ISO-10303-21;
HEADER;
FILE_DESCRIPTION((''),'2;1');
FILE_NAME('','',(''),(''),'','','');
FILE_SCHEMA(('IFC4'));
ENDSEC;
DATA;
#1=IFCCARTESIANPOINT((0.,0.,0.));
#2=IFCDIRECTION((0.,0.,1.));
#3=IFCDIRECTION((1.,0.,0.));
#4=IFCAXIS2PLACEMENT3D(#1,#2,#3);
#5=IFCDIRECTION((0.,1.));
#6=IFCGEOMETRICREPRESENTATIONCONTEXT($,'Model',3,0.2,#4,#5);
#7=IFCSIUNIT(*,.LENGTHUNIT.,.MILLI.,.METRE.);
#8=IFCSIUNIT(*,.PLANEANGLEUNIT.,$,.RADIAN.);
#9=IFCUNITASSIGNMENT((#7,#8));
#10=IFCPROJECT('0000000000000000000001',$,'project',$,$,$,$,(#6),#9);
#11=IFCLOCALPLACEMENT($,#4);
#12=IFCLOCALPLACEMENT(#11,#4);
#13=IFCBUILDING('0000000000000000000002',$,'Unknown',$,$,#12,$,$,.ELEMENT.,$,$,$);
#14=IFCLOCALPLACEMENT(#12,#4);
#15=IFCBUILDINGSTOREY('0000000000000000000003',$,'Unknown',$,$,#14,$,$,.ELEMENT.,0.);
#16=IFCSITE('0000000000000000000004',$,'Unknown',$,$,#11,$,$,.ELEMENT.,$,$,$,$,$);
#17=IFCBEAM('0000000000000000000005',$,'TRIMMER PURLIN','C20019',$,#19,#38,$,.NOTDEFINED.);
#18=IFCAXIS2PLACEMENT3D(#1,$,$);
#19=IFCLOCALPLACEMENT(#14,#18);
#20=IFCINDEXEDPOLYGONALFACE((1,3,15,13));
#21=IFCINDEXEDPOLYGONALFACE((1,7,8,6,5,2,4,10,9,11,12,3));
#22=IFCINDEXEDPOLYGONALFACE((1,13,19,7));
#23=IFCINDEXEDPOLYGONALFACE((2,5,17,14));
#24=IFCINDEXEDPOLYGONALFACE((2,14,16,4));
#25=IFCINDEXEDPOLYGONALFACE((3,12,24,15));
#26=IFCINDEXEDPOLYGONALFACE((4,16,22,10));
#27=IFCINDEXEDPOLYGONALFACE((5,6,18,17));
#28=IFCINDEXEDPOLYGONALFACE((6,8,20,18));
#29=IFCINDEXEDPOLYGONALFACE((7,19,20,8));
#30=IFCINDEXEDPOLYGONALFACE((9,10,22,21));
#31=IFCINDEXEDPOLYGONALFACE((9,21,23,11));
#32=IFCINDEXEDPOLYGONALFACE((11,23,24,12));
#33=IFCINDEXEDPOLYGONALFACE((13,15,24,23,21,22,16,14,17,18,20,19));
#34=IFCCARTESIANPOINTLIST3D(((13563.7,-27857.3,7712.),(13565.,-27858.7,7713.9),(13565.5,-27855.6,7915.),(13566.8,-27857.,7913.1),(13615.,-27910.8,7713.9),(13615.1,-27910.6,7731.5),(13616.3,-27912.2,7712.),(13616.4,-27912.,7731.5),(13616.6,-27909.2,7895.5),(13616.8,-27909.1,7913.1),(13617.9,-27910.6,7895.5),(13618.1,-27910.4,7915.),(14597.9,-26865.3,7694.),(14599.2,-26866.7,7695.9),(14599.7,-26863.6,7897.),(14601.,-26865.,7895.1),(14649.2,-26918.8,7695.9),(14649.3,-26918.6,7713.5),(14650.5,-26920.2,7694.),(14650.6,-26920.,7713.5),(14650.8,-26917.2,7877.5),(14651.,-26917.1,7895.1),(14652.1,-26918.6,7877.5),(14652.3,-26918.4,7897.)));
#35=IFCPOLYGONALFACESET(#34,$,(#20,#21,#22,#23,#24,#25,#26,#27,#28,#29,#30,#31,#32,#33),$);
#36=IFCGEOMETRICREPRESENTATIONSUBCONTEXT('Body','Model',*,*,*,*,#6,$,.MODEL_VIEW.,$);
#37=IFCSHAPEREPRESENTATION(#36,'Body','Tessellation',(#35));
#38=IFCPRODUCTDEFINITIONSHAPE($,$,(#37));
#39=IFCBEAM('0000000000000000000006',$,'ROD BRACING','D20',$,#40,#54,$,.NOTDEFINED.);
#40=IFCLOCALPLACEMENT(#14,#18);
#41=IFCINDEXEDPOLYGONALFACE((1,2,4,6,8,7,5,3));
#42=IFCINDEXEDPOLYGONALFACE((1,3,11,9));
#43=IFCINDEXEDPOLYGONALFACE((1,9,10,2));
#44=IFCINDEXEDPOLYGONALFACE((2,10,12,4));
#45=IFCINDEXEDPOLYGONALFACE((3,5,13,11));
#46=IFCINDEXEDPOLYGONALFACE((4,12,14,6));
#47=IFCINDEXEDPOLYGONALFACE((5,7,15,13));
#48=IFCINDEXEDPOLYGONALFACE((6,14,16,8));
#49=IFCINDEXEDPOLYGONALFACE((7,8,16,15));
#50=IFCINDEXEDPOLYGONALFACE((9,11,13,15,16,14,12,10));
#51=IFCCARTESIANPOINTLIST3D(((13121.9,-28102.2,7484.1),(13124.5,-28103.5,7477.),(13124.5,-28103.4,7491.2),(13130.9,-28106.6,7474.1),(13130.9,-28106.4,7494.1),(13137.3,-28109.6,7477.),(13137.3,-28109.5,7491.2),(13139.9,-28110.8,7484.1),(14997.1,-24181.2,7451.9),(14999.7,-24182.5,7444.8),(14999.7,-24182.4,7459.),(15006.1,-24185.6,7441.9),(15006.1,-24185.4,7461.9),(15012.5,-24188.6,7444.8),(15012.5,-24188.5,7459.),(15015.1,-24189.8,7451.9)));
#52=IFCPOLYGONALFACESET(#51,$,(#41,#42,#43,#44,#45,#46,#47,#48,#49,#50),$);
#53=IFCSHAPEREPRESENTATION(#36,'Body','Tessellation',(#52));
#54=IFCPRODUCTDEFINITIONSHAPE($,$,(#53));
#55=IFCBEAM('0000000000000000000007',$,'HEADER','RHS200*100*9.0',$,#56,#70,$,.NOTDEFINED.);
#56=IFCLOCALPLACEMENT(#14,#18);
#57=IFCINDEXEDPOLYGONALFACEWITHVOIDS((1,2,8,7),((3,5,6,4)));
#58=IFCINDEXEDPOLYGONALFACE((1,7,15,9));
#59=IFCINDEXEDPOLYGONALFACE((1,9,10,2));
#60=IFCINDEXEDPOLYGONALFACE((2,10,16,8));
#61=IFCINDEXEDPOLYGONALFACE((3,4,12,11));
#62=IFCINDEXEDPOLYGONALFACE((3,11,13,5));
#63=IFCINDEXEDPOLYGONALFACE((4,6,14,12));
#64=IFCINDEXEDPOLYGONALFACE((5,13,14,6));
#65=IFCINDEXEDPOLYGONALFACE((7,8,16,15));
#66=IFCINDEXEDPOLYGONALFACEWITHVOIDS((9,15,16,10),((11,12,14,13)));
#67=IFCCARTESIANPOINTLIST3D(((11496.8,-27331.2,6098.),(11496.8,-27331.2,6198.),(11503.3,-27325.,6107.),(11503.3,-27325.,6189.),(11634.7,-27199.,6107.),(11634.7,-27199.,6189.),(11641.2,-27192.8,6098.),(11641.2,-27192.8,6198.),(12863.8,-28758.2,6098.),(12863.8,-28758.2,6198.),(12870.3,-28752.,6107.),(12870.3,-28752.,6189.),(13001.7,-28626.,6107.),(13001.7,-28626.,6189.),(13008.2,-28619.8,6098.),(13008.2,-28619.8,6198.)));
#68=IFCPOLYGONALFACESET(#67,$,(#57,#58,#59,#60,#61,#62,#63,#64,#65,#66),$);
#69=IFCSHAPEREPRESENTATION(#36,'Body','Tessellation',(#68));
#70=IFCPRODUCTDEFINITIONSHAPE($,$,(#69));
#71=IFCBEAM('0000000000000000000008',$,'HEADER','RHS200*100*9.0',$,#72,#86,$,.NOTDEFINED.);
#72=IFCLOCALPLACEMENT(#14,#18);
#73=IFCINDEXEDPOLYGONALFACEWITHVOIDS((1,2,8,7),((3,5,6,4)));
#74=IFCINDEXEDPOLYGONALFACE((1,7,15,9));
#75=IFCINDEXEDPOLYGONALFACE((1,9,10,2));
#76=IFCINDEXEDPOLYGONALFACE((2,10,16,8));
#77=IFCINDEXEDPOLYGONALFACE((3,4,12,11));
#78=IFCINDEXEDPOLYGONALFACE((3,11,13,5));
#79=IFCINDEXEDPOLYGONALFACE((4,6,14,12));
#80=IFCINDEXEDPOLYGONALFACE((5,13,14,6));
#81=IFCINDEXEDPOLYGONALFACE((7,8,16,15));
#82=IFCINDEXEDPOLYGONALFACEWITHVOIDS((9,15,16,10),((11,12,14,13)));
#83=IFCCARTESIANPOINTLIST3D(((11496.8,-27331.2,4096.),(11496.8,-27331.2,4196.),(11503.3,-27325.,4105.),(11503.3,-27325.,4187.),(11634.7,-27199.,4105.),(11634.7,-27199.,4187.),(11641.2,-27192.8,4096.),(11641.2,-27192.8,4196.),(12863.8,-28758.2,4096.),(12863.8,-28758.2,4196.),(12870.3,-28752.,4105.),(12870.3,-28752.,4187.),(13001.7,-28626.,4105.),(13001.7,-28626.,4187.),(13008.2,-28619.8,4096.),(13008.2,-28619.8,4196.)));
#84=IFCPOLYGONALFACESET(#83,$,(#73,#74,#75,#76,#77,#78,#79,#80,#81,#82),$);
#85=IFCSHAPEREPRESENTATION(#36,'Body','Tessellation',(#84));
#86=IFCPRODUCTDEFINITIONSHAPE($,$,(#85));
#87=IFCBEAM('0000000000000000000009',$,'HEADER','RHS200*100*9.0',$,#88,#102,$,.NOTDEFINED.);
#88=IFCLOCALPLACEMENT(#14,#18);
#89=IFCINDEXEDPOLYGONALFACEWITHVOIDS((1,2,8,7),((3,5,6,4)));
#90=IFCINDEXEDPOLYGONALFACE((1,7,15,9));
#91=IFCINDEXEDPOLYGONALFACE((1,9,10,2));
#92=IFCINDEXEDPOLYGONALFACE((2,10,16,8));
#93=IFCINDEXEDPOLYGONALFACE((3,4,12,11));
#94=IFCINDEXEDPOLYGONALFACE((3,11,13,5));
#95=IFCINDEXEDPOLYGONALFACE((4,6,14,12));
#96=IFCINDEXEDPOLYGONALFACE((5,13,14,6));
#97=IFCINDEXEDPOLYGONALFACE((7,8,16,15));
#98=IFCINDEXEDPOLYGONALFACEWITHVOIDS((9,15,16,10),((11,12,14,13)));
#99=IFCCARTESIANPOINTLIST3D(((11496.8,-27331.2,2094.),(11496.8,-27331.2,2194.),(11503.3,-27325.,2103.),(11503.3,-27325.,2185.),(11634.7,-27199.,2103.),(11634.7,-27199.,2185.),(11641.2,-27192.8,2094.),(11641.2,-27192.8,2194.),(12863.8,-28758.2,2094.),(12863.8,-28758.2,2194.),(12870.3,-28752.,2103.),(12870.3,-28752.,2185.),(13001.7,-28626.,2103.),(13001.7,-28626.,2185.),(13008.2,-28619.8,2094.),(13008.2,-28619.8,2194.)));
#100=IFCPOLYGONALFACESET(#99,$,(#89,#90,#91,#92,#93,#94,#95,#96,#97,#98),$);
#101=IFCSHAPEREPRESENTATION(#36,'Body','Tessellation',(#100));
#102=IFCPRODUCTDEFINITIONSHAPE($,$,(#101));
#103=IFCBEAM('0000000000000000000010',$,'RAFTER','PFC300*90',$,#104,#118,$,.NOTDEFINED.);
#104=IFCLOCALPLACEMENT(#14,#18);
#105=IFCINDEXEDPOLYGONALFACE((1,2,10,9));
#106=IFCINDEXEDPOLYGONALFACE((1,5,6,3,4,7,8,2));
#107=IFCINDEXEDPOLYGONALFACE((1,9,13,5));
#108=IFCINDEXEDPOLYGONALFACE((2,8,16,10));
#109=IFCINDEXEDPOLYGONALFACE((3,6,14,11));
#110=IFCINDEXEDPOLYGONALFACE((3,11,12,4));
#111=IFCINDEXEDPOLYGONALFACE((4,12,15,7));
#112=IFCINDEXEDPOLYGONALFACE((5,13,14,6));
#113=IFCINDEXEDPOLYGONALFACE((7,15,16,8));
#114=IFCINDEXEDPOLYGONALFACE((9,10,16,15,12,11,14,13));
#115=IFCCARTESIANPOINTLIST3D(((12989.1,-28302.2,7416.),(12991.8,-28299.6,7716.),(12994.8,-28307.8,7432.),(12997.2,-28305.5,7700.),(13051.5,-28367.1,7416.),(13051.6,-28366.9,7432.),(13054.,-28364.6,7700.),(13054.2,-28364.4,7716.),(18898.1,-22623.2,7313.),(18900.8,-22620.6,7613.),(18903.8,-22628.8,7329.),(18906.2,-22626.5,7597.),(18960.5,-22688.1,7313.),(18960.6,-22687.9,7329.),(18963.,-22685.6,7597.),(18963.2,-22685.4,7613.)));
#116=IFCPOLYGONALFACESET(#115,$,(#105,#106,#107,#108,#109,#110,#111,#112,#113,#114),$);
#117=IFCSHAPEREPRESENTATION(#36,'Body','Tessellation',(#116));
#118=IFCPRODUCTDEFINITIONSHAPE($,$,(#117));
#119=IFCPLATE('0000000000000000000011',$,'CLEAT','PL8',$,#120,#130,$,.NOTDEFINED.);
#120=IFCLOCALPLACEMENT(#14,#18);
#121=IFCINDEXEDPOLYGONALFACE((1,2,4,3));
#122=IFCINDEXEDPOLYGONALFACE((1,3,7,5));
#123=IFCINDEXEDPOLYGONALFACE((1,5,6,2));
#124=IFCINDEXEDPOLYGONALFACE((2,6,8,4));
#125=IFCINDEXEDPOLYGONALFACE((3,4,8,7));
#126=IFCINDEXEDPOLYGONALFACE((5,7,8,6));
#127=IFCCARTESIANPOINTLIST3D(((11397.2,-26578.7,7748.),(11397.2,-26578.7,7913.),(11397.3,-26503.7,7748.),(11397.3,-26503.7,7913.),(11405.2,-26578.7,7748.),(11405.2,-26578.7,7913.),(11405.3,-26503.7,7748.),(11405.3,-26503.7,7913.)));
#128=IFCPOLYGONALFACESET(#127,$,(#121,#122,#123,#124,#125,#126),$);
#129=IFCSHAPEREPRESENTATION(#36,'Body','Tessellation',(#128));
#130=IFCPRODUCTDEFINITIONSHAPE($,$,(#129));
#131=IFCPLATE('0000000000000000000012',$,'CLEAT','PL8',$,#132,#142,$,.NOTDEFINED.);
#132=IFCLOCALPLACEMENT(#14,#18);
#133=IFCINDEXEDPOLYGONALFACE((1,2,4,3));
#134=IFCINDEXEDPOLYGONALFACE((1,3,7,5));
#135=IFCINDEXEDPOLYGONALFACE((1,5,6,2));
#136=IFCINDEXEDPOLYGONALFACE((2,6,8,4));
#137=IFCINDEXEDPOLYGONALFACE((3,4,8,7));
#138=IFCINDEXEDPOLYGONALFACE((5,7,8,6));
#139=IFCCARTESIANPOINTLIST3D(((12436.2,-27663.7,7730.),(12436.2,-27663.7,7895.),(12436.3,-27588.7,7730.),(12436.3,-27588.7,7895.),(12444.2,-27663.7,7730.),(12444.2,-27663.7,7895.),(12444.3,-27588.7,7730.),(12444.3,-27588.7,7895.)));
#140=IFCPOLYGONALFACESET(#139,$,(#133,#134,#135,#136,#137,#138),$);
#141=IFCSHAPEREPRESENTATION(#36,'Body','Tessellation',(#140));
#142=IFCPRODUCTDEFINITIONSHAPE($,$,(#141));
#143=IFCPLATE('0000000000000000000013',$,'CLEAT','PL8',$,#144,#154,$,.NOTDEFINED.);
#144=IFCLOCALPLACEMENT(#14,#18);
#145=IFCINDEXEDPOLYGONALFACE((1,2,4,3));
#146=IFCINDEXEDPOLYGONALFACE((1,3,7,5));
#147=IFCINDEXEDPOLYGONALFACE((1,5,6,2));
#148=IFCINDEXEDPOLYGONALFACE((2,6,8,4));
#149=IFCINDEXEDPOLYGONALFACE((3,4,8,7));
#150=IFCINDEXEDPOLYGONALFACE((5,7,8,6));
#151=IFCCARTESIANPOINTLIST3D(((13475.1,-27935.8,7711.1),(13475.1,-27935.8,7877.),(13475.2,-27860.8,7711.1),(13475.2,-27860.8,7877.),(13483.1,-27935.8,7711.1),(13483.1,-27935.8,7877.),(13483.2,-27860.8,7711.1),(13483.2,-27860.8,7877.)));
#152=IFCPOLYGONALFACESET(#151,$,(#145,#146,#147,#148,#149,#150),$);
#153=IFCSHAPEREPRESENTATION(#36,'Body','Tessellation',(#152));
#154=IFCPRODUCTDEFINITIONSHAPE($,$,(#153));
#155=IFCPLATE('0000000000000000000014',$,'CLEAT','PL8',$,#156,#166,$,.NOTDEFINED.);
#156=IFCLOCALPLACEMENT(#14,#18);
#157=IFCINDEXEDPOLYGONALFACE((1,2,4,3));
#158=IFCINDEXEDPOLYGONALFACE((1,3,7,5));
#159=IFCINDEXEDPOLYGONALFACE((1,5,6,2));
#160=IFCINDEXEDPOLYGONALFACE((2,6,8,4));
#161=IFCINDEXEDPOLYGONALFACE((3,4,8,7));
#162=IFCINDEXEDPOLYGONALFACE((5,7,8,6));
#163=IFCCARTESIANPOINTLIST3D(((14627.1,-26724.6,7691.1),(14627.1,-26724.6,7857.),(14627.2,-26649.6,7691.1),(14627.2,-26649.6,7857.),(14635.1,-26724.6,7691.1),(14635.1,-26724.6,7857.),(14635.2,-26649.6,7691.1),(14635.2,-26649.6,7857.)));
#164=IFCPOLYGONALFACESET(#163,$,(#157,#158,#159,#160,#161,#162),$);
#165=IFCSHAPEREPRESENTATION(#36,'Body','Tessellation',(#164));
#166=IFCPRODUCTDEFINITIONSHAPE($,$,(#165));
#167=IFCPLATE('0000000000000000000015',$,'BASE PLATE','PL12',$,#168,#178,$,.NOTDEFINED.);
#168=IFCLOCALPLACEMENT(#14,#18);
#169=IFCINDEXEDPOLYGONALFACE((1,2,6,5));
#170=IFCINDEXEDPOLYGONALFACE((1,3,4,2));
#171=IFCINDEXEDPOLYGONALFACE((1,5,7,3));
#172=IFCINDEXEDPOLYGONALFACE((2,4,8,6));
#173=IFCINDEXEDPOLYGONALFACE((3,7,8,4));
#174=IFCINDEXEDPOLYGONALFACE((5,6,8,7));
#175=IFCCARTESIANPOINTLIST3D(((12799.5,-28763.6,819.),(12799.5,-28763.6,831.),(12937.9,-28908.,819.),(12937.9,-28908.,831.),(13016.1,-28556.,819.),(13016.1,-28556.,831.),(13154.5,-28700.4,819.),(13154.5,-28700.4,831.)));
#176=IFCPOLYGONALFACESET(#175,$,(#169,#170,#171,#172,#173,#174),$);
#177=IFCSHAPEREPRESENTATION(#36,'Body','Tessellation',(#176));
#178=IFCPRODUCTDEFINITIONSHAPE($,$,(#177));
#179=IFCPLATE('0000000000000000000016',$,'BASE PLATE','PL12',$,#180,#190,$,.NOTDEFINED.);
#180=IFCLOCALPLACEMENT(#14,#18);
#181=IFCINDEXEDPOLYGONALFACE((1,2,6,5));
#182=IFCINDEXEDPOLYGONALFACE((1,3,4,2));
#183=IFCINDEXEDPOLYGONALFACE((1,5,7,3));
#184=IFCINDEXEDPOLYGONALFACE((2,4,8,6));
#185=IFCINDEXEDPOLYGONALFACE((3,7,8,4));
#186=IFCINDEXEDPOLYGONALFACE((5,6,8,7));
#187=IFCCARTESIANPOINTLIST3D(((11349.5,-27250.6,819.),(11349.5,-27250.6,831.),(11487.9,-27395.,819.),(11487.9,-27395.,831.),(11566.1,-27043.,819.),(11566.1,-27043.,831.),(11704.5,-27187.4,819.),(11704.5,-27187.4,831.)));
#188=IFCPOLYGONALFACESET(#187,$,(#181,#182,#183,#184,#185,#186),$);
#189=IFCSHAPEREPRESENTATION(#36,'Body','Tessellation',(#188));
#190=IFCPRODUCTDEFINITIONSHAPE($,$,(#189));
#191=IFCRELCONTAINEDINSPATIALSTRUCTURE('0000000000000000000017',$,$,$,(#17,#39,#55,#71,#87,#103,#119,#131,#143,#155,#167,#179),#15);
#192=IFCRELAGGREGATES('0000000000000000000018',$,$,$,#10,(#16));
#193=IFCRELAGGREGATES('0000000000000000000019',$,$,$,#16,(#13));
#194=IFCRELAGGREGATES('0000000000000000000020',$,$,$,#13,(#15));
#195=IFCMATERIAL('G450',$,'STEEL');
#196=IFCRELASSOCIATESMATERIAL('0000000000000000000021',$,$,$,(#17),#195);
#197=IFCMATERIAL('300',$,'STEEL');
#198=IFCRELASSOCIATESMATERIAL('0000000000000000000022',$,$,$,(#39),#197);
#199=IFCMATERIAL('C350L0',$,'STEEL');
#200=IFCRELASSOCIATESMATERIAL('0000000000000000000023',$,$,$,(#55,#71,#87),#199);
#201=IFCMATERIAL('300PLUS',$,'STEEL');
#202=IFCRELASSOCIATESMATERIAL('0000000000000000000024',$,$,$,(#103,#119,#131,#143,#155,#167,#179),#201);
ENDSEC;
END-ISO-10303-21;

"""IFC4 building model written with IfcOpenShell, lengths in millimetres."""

from ifc_helpers import new_model, si_unit, direction, frame, origin_with_axes, place, context, subcontext, project, spatial, line, indexed_curve, outline, extrude, material, element, save


model = new_model("IFC4")

# Units and contexts
model_context = context("Model", 3, precision=0.2, world=origin_with_axes(), true_north=direction((0.0, 1.0)))
body_context = subcontext(model_context, "Body", "Model", "MODEL_VIEW")
ifc_project = project(units=[si_unit("LENGTHUNIT", "METRE", prefix="MILLI"), si_unit("PLANEANGLEUNIT", "RADIAN")], contexts=[model_context])

# Site, building, storey
site_placement = place(None, origin_with_axes())
site = spatial("IfcSite", under=ifc_project, at=site_placement, Name="Unknown", CompositionType="ELEMENT")
building_placement = place(site_placement, origin_with_axes())
building = spatial("IfcBuilding", under=site, at=building_placement, Name="Unknown", CompositionType="ELEMENT")
storey_placement = place(building_placement, origin_with_axes())
storey = spatial("IfcBuildingStorey", under=building, at=storey_placement, Name="Unknown", CompositionType="ELEMENT", Elevation=0.0)

# Shared definitions
ifc_material_1 = material(Name="C350L0", Category="STEEL")

# Beams
ifc_material_2 = material(Name="G450", Category="STEEL")
beam_1_placement = place(storey_placement, frame((13590.9, -27883.9, 7813.5), z_axis=(0.69223, -0.721677, 0.0), x_axis=(0.72162, 0.692175, -0.01256)))
element("IfcBeam", 1, at=beam_1_placement, inside=storey, material=ifc_material_2, Name="TRIMMER PURLIN", Description="C20019", PredefinedType="NOTDEFINED", context=body_context, shape_type="SolidModel", body=[
    extrude(outline(indexed_curve([(38.0, -101.5), (38.0, -82.0), (36.1, -82.0), (36.1, -99.6), (-36.1, -99.6), (-36.1, 99.6), (36.1, 99.6), (36.1, 82.0), (38.0, 82.0), (38.0, 101.5), (-38.0, 101.5), (-38.0, -101.5)], segments=[line(1, 2, 3, 4, 5, 6, 7, 8, 9, 10, 11, 12, 1)])), frame((0.0, 0.0, 0.0), z_axis=(-1.0, 0.0, 0.0), x_axis=(0.0, 0.0, 1.0)), (0.0, 0.0, -1.0), 1433.2),
])
ifc_material_3 = material(Name="300", Category="STEEL")
beam_2_placement = place(storey_placement, frame((13130.9, -28106.5, 7484.1), z_axis=(0.003196, 0.006683, 0.999973), x_axis=(0.431432, 0.902115, -0.007408)))
element("IfcBeam", 2, at=beam_2_placement, inside=storey, material=ifc_material_3, Name="ROD BRACING", Description="D20", PredefinedType="NOTDEFINED", context=body_context, shape_type="SolidModel", body=[
    extrude(outline(indexed_curve([(10.0, 0.0), (7.1, 7.1), (0.0, 10.0), (-7.1, 7.1), (-10.0, 0.0), (-7.1, -7.1), (0.0, -10.0), (7.1, -7.1)], segments=[line(1, 2, 3, 4, 5, 6, 7, 8, 1)])), frame((0.0, 0.0, 0.0), z_axis=(-1.0, 0.0, 0.0), x_axis=(0.0, 0.0, 1.0)), (0.0, 0.0, -1.0), 4346.5),
])
for number, where, z_axis, x_axis, name in (
    (3, (11569.0, -27262.0, 6148.0), (0.0, 0.0, 1.0), (0.691762, -0.722125, 0.0), "HEADER"),
    (4, (11569.0, -27262.0, 4146.0), (0.0, 0.0, 1.0), (0.691762, -0.722125, 0.0), "HEADER"),
    (5, (11569.0, -27262.0, 2144.0), (0.0, 0.0, 1.0), (0.691762, -0.722125, 0.0), "HEADER"),
):
    element("IfcBeam", number, at=place(storey_placement, frame(where, z_axis=z_axis, x_axis=x_axis)), inside=storey, material=ifc_material_1, Name=name, Description="RHS200*100*9.0", PredefinedType="NOTDEFINED", context=body_context, shape_type="SolidModel", body=[
        extrude(outline(indexed_curve([(-50.0, -100.0), (50.0, -100.0), (50.0, 100.0), (-50.0, 100.0)], segments=[line(1, 2, 3, 4, 1)]), holes=[indexed_curve([(-41.0, -91.0), (-41.0, 91.0), (41.0, 91.0), (41.0, -91.0)], segments=[line(1, 2, 3, 4, 1)])]), frame((0.0, 0.0, 0.0), z_axis=(-1.0, 0.0, 0.0), x_axis=(0.0, 0.0, 1.0)), (0.0, 0.0, -1.0), 1976.1),
    ])
ifc_material_4 = material(Name="300PLUS", Category="STEEL")
beam_3_placement = place(storey_placement, frame((13021.6, -28333.3, 7566.0), z_axis=(0.692936, -0.721, 0.0), x_axis=(0.720943, 0.692881, -0.012567)))
element("IfcBeam", 6, at=beam_3_placement, inside=storey, material=ifc_material_4, Name="RAFTER", Description="PFC300*90", PredefinedType="NOTDEFINED", context=body_context, shape_type="SolidModel", body=[
    extrude(outline(indexed_curve([(-45.0, -150.0), (45.0, -150.0), (45.0, -134.0), (-37.0, -134.0), (-37.0, 134.0), (45.0, 134.0), (45.0, 150.0), (-45.0, 150.0)], segments=[line(1, 2, 3, 4, 5, 6, 7, 8, 1)])), frame((0.0, 0.0, 0.0), z_axis=(-1.0, 0.0, 0.0), x_axis=(0.0, 0.0, 1.0)), (0.0, 0.0, -1.0), 8196.2),
])

# Plates
for number, where, z_axis, x_axis, name in (
    (7, (11401.3, -26503.7, 7913.0), (0.999999, -0.001333, 0.0), (-0.001333, -0.999999, 0.0), "CLEAT"),
    (8, (12440.3, -27588.7, 7895.0), (0.999999, -0.001333, 0.0), (-0.001333, -0.999999, 0.0), "CLEAT"),
):
    element("IfcPlate", number, at=place(storey_placement, frame(where, z_axis=z_axis, x_axis=x_axis)), inside=storey, material=ifc_material_4, Name=name, Description="PL8", PredefinedType="NOTDEFINED", context=body_context, shape_type="SolidModel", body=[
        extrude(outline(indexed_curve([(0.0, 0.0), (75.0, 0.0), (75.0, 165.0), (0.0, 165.0)], segments=[line(1, 2, 3, 4, 1)])), frame((0.0, 0.0, 4.0), z_axis=(0.0, 0.0, 1.0), x_axis=(1.0, 0.0, 0.0)), (0.0, 0.0, -1.0), 8.0),
    ])
for number, where, z_axis, x_axis, name in (
    (9, (13479.2, -27860.8, 7877.0), (0.999999, -0.001333, 0.0), (-0.001333, -0.999999, 0.0), "CLEAT"),
    (10, (14631.2, -26649.6, 7857.0), (0.999999, -0.001333, 0.0), (-0.001333, -0.999999, 0.0), "CLEAT"),
):
    element("IfcPlate", number, at=place(storey_placement, frame(where, z_axis=z_axis, x_axis=x_axis)), inside=storey, material=ifc_material_4, Name=name, Description="PL8", PredefinedType="NOTDEFINED", context=body_context, shape_type="SolidModel", body=[
        extrude(outline(indexed_curve([(0.0, 0.0), (75.0, 0.0), (75.0, 165.9), (0.0, 165.9)], segments=[line(1, 2, 3, 4, 1)])), frame((0.0, 0.0, 4.0), z_axis=(0.0, 0.0, 1.0), x_axis=(1.0, 0.0, 0.0)), (0.0, 0.0, -1.0), 8.0),
    ])
for number, where, z_axis, x_axis, name in (
    (11, (12937.9, -28908.0, 825.0), (0.0, 0.0, 1.0), (0.721947, 0.691949, 0.0), "BASE PLATE"),
    (12, (11487.9, -27395.0, 825.0), (0.0, 0.0, 1.0), (0.721947, 0.691949, 0.0), "BASE PLATE"),
):
    element("IfcPlate", number, at=place(storey_placement, frame(where, z_axis=z_axis, x_axis=x_axis)), inside=storey, material=ifc_material_4, Name=name, Description="PL12", PredefinedType="NOTDEFINED", context=body_context, shape_type="SolidModel", body=[
        extrude(outline(indexed_curve([(0.0, 0.0), (300.0, 0.0), (300.0, 200.0), (0.0, 200.0)], segments=[line(1, 2, 3, 4, 1)])), frame((0.0, 0.0, 6.0), z_axis=(0.0, 0.0, 1.0), x_axis=(1.0, 0.0, 0.0)), (0.0, 0.0, -1.0), 12.0),
    ])

save(model, "model.ifc")
